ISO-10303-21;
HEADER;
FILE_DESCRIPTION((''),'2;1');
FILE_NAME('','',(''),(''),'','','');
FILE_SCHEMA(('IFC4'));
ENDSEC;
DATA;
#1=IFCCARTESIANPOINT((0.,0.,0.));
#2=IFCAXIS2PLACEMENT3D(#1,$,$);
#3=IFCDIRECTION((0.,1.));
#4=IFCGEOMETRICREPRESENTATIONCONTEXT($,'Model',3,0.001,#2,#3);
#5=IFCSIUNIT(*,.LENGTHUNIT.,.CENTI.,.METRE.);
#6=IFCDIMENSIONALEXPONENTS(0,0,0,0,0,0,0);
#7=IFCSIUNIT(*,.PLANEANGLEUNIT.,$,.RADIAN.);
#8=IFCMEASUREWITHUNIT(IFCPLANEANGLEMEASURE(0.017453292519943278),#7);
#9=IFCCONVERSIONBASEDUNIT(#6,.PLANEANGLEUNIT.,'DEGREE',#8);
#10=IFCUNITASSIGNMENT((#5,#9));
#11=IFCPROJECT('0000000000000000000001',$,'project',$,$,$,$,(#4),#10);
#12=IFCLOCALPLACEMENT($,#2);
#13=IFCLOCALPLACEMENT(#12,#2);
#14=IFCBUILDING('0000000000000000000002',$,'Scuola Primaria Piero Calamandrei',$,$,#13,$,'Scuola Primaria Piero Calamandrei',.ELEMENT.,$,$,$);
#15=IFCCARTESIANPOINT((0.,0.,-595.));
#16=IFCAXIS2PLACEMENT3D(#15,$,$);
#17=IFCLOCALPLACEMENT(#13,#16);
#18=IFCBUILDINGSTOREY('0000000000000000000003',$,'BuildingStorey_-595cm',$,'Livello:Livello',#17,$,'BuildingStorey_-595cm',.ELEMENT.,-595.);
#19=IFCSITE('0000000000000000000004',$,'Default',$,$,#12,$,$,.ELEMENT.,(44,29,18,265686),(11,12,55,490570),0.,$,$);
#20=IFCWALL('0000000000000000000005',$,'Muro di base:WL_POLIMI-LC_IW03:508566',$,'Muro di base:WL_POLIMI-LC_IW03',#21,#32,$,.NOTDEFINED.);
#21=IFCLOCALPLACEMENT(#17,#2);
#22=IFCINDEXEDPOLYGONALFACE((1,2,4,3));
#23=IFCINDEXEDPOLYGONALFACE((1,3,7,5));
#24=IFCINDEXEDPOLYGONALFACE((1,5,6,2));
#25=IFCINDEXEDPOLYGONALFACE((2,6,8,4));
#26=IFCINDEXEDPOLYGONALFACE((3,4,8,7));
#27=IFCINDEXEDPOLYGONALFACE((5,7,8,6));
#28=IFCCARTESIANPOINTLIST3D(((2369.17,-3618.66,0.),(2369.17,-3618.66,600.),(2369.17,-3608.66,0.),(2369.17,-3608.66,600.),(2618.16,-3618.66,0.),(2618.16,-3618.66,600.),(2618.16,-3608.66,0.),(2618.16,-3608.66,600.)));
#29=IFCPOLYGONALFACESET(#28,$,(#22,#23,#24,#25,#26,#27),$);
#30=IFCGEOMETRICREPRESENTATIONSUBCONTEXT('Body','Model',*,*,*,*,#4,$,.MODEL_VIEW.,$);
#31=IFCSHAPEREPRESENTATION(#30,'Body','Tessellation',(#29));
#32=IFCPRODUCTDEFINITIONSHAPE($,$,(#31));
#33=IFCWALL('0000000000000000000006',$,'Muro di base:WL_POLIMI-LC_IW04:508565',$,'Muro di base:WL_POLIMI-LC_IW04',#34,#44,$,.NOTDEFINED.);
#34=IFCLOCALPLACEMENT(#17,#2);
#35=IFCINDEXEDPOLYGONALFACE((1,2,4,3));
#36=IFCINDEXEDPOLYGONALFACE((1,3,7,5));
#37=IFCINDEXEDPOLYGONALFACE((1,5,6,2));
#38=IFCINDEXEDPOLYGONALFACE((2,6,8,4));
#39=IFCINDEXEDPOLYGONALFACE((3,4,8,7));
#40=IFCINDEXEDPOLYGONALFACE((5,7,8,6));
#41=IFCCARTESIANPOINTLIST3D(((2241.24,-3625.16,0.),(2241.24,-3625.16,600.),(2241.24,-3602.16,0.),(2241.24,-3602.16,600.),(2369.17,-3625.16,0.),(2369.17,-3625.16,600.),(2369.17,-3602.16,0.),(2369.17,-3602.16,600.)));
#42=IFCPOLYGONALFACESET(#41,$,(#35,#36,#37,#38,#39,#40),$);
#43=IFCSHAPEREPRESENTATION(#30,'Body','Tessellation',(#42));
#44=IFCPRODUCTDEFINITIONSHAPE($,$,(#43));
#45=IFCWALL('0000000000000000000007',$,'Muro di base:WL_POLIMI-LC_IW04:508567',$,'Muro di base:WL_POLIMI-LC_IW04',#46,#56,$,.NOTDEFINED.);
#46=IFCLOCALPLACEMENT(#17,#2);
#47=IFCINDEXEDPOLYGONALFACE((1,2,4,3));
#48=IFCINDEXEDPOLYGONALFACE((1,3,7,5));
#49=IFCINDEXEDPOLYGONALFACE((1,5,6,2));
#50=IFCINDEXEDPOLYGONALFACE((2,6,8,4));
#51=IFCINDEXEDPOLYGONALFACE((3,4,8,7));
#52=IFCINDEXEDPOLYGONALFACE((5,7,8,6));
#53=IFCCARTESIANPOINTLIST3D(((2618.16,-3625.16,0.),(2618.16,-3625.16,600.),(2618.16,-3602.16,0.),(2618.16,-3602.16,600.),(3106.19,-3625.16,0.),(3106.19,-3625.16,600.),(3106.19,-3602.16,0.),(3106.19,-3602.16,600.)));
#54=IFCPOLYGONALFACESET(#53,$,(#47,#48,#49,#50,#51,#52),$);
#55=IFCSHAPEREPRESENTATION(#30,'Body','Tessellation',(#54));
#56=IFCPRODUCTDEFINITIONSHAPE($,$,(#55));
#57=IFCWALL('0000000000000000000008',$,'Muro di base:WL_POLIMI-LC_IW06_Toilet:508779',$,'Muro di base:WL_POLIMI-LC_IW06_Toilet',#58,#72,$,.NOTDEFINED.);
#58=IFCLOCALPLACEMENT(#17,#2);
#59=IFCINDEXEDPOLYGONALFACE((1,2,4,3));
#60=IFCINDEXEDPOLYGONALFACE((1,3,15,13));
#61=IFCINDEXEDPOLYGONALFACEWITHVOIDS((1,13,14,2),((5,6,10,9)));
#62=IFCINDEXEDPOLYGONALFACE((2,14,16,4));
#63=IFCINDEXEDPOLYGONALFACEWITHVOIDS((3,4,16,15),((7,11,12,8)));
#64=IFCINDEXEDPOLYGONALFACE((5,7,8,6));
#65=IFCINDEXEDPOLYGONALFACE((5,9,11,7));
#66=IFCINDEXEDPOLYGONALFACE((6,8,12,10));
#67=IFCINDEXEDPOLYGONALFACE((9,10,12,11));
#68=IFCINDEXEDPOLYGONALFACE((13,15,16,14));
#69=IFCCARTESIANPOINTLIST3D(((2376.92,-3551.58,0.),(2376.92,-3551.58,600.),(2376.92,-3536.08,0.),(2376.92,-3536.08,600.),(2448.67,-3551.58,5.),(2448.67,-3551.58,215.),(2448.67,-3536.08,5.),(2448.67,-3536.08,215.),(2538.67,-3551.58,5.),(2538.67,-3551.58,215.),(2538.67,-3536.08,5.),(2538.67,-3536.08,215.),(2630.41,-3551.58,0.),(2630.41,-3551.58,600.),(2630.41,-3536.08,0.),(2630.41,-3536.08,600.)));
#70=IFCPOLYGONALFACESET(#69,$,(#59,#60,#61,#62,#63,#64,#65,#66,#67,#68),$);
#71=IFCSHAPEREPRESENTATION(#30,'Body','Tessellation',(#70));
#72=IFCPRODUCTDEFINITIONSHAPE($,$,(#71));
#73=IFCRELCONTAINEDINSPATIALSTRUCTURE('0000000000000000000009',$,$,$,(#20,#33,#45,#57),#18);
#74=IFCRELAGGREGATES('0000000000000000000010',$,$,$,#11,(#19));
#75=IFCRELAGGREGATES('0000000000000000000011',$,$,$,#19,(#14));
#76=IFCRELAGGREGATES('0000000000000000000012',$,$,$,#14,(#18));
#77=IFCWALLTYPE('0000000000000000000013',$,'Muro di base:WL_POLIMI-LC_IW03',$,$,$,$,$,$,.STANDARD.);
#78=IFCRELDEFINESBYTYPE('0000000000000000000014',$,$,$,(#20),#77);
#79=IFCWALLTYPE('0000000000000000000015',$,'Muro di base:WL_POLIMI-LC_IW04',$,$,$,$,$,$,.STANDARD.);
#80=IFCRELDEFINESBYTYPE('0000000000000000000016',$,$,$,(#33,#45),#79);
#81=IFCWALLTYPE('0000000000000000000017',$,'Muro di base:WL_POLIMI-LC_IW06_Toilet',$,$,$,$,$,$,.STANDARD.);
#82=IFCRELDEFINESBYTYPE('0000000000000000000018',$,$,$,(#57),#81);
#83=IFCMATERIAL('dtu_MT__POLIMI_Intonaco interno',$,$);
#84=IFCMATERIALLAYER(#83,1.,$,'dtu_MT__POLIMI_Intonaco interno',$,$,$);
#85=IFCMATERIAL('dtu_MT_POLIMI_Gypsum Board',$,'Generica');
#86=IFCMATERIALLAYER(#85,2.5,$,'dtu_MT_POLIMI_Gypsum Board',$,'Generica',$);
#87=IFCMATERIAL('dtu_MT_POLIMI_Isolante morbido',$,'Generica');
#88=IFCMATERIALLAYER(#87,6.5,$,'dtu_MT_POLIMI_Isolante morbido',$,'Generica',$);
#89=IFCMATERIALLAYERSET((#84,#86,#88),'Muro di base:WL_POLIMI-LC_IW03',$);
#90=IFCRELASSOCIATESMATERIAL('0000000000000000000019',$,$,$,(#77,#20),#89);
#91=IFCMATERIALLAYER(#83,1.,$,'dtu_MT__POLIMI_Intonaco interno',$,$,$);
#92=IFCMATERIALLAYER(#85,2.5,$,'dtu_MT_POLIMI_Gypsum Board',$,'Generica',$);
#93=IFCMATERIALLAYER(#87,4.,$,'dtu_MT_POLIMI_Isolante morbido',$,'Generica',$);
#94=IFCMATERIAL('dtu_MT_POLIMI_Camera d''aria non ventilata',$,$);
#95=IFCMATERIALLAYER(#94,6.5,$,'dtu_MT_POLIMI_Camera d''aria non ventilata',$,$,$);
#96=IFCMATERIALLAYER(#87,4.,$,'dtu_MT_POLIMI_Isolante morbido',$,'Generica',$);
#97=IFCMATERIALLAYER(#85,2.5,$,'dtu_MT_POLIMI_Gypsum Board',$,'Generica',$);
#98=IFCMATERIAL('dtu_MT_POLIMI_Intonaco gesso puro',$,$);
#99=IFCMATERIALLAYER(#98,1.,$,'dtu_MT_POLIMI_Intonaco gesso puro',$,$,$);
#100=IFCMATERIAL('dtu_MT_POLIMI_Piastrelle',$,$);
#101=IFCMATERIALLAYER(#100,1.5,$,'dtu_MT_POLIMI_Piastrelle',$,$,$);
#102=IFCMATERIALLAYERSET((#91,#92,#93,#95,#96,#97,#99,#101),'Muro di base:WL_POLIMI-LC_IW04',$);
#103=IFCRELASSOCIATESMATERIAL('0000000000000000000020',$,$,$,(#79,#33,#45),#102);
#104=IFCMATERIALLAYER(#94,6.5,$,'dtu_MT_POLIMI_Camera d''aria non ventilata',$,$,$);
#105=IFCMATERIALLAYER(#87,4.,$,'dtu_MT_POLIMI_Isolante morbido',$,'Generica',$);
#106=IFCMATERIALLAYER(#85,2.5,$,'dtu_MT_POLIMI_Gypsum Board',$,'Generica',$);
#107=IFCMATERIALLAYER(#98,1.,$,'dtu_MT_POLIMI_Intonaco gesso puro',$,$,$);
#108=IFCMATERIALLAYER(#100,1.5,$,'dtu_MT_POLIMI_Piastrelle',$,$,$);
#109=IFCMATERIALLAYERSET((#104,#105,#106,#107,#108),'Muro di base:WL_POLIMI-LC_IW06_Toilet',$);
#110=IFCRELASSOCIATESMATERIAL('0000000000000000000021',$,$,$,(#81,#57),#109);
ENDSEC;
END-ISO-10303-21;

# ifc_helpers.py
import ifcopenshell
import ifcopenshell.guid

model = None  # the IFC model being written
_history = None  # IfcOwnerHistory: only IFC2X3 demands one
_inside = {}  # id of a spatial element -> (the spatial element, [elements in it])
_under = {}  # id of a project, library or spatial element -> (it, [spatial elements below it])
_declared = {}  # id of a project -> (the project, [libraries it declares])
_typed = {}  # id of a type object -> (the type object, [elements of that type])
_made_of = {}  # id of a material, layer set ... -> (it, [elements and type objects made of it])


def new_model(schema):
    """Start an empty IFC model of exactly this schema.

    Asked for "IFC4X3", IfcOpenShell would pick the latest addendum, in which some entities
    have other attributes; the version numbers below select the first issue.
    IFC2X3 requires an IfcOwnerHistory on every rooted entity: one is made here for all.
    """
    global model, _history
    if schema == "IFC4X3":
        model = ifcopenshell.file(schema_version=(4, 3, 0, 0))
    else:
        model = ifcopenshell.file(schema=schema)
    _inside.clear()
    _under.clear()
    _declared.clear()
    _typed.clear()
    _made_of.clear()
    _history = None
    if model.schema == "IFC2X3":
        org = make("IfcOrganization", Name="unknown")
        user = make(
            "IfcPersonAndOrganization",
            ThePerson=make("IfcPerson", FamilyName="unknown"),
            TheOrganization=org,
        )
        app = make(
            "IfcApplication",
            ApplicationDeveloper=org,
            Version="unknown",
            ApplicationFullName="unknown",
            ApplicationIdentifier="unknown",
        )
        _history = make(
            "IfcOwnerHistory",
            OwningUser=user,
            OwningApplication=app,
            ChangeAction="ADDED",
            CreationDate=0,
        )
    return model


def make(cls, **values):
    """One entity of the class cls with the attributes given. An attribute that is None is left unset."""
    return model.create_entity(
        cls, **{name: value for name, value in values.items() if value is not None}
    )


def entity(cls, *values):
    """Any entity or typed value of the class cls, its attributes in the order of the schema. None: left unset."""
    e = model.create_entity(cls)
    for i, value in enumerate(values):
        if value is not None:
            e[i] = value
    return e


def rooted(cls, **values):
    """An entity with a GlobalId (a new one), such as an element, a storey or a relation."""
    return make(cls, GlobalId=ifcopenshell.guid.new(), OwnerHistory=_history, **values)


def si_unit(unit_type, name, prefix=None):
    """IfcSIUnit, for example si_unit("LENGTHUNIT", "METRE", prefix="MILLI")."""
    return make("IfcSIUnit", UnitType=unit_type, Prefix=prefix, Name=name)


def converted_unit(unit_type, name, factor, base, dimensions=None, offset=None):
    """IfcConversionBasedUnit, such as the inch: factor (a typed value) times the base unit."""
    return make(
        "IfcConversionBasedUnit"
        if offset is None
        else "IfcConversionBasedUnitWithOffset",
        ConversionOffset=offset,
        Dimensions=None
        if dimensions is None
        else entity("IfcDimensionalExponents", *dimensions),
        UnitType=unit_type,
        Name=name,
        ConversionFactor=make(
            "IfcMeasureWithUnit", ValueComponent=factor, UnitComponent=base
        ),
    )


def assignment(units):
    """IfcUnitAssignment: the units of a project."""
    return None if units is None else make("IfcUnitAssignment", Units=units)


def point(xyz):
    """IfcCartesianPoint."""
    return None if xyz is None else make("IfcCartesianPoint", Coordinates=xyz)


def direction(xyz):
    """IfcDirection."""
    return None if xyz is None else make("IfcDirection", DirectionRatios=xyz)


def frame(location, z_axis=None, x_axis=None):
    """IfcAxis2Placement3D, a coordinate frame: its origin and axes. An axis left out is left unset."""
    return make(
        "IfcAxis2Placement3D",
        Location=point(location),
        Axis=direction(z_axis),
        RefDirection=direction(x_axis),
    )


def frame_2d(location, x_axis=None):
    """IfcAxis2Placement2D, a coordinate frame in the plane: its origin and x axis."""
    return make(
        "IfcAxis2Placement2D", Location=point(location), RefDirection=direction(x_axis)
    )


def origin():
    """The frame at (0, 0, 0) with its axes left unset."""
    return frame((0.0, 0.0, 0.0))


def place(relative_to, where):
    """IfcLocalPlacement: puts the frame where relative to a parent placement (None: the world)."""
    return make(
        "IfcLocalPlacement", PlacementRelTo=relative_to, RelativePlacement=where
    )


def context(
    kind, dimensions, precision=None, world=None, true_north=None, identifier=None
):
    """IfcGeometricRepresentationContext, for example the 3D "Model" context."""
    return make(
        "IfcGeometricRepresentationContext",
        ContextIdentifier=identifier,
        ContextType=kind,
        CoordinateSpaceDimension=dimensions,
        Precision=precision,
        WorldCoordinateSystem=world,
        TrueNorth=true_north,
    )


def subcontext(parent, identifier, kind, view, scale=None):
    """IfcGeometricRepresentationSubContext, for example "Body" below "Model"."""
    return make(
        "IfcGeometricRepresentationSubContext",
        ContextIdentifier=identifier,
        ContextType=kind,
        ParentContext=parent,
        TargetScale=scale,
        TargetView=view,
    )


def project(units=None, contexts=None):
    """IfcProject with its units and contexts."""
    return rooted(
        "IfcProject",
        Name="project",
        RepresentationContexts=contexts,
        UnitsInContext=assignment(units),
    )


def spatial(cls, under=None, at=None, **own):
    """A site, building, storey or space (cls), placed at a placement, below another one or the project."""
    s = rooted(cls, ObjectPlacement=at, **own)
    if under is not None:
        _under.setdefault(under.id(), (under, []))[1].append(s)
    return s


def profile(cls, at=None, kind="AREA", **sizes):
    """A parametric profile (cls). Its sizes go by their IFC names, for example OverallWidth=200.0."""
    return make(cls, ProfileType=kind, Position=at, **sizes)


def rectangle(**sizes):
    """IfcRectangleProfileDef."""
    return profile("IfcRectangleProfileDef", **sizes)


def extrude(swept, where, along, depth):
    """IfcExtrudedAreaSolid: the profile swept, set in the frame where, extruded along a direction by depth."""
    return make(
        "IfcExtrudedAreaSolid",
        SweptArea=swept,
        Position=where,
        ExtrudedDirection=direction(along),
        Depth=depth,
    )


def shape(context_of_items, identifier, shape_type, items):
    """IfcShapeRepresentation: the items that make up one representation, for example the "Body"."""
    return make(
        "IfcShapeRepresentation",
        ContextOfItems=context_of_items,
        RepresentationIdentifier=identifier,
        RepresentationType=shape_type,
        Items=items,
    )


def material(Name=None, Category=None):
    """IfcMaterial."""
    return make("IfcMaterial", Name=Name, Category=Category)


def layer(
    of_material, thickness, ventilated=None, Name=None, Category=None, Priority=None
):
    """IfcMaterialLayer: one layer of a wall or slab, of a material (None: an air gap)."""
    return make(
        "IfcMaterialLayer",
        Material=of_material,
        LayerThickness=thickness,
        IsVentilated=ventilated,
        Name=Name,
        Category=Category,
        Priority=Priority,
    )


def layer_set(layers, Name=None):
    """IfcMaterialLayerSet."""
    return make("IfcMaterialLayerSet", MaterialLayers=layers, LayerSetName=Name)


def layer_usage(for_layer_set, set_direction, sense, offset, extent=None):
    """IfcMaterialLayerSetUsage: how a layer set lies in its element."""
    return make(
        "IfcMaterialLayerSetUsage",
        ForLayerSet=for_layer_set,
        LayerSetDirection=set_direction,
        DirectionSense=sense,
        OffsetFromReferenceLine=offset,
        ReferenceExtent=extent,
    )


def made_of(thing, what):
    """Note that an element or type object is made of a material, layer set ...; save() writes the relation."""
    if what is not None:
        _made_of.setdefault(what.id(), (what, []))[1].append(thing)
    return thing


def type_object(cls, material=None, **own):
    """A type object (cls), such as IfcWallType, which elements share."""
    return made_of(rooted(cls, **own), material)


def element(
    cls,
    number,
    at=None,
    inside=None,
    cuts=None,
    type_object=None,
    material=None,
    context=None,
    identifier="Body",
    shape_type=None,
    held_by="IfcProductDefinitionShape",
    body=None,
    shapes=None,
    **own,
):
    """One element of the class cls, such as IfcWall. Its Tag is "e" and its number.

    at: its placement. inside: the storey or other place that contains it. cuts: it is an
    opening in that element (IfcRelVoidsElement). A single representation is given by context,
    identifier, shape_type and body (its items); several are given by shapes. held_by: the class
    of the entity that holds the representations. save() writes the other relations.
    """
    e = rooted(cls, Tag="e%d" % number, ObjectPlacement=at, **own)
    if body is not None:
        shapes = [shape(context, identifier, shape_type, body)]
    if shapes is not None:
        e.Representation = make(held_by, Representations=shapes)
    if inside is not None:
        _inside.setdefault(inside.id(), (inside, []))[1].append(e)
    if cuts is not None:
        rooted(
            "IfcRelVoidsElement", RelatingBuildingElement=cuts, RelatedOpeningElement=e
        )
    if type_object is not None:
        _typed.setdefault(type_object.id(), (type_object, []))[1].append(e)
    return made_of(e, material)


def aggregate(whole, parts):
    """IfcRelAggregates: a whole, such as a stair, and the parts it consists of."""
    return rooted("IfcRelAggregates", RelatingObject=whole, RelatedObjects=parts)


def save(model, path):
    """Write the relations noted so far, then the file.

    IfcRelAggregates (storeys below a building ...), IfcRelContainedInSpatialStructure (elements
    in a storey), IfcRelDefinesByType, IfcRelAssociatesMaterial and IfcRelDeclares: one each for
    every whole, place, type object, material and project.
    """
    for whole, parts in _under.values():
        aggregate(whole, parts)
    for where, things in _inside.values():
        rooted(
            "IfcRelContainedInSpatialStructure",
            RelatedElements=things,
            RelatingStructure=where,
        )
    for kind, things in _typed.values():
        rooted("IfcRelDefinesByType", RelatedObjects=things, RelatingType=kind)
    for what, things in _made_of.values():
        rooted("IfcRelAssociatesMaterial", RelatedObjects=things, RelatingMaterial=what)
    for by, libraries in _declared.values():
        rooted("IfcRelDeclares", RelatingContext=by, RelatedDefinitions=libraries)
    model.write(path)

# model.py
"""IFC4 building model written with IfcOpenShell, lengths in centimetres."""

from ifc_helpers import new_model, entity, si_unit, converted_unit, direction, frame, frame_2d, origin, place, context, subcontext, project, spatial, rectangle, extrude, material, layer, layer_set, layer_usage, type_object, element, save


model = new_model("IFC4")

# Units and contexts
model_context = context("Model", 3, precision=0.001, world=origin(), true_north=direction((0.0, 1.0)))
body_context = subcontext(model_context, "Body", "Model", "MODEL_VIEW")
ifc_project = project(units=[si_unit("LENGTHUNIT", "METRE", prefix="CENTI"), converted_unit("PLANEANGLEUNIT", "DEGREE", entity("IfcPlaneAngleMeasure", 0.017453292519943278), si_unit("PLANEANGLEUNIT", "RADIAN"), dimensions=[0, 0, 0, 0, 0, 0, 0])], contexts=[model_context])

# Site, building, storey
site_placement = place(None, origin())
site = spatial("IfcSite", under=ifc_project, at=site_placement, Name="Default", CompositionType="ELEMENT", RefLatitude=(44, 29, 18, 265686), RefLongitude=(11, 12, 55, 490570), RefElevation=0.0)
building_placement = place(site_placement, origin())
building = spatial("IfcBuilding", under=site, at=building_placement, Name="Scuola Primaria Piero Calamandrei", LongName="Scuola Primaria Piero Calamandrei", CompositionType="ELEMENT")
storey_placement = place(building_placement, frame((0.0, 0.0, -595.0)))
storey = spatial("IfcBuildingStorey", under=building, at=storey_placement, Name="BuildingStorey_-595cm", ObjectType="Livello:Livello", LongName="BuildingStorey_-595cm", CompositionType="ELEMENT", Elevation=-595.0)

# Shared definitions
ifc_material_1 = material(Name="dtu_MT__POLIMI_Intonaco interno")
ifc_material_2 = material(Name="dtu_MT_POLIMI_Gypsum Board", Category="Generica")
ifc_material_3 = material(Name="dtu_MT_POLIMI_Isolante morbido", Category="Generica")
ifc_material_4 = material(Name="dtu_MT_POLIMI_Camera d'aria non ventilata")
ifc_material_5 = material(Name="dtu_MT_POLIMI_Intonaco gesso puro")

# Walls
ifc_layer_1 = layer(ifc_material_1, 1.0, Name="dtu_MT__POLIMI_Intonaco interno")
ifc_layer_2 = layer(ifc_material_2, 2.5, Name="dtu_MT_POLIMI_Gypsum Board", Category="Generica")
ifc_layer_3 = layer(ifc_material_3, 6.5, Name="dtu_MT_POLIMI_Isolante morbido", Category="Generica")
ifc_layer_set_1 = layer_set([ifc_layer_1, ifc_layer_2, ifc_layer_3], Name="Muro di base:WL_POLIMI-LC_IW03")
ifc_layer_usage_1 = layer_usage(ifc_layer_set_1, "AXIS2", "NEGATIVE", 5.0)
wall_type_1 = type_object("IfcWallType", Name="Muro di base:WL_POLIMI-LC_IW03", PredefinedType="STANDARD", material=ifc_layer_set_1)
wall_1_placement = place(storey_placement, frame((2369.17, -3613.66, 0.0)))
element("IfcWall", 1, at=wall_1_placement, inside=storey, type_object=wall_type_1, material=ifc_layer_usage_1, Name="Muro di base:WL_POLIMI-LC_IW03:508566", ObjectType="Muro di base:WL_POLIMI-LC_IW03", PredefinedType="NOTDEFINED", context=body_context, shape_type="SweptSolid", body=[
    extrude(rectangle(XDim=248.99, YDim=10.0, at=frame_2d((124.5, 0.0), x_axis=(-1.0, 0.0))), origin(), (0.0, 0.0, 1.0), 600.0),
])
ifc_layer_4 = layer(ifc_material_1, 1.0, Name="dtu_MT__POLIMI_Intonaco interno")
ifc_layer_5 = layer(ifc_material_2, 2.5, Name="dtu_MT_POLIMI_Gypsum Board", Category="Generica")
ifc_layer_6 = layer(ifc_material_3, 4.0, Name="dtu_MT_POLIMI_Isolante morbido", Category="Generica")
ifc_layer_7 = layer(ifc_material_4, 6.5, Name="dtu_MT_POLIMI_Camera d'aria non ventilata")
ifc_layer_8 = layer(ifc_material_3, 4.0, Name="dtu_MT_POLIMI_Isolante morbido", Category="Generica")
ifc_layer_9 = layer(ifc_material_2, 2.5, Name="dtu_MT_POLIMI_Gypsum Board", Category="Generica")
ifc_layer_10 = layer(ifc_material_5, 1.0, Name="dtu_MT_POLIMI_Intonaco gesso puro")
ifc_material_6 = material(Name="dtu_MT_POLIMI_Piastrelle")
ifc_layer_11 = layer(ifc_material_6, 1.5, Name="dtu_MT_POLIMI_Piastrelle")
ifc_layer_set_2 = layer_set([ifc_layer_4, ifc_layer_5, ifc_layer_6, ifc_layer_7, ifc_layer_8, ifc_layer_9, ifc_layer_10, ifc_layer_11], Name="Muro di base:WL_POLIMI-LC_IW04")
ifc_layer_usage_2 = layer_usage(ifc_layer_set_2, "AXIS2", "NEGATIVE", 11.5)
wall_type_2 = type_object("IfcWallType", Name="Muro di base:WL_POLIMI-LC_IW04", PredefinedType="STANDARD", material=ifc_layer_set_2)
wall_2_placement = place(storey_placement, frame((2241.24, -3613.66, 0.0)))
element("IfcWall", 2, at=wall_2_placement, inside=storey, type_object=wall_type_2, material=ifc_layer_usage_2, Name="Muro di base:WL_POLIMI-LC_IW04:508565", ObjectType="Muro di base:WL_POLIMI-LC_IW04", PredefinedType="NOTDEFINED", context=body_context, shape_type="SweptSolid", body=[
    extrude(rectangle(XDim=127.93, YDim=23.0, at=frame_2d((63.97, 0.0), x_axis=(-1.0, 0.0))), origin(), (0.0, 0.0, 1.0), 600.0),
])
ifc_layer_usage_3 = layer_usage(ifc_layer_set_2, "AXIS2", "NEGATIVE", 11.5)
wall_3_placement = place(storey_placement, frame((2618.16, -3613.66, 0.0)))
element("IfcWall", 3, at=wall_3_placement, inside=storey, type_object=wall_type_2, material=ifc_layer_usage_3, Name="Muro di base:WL_POLIMI-LC_IW04:508567", ObjectType="Muro di base:WL_POLIMI-LC_IW04", PredefinedType="NOTDEFINED", context=body_context, shape_type="SweptSolid", body=[
    extrude(rectangle(XDim=488.02, YDim=23.0, at=frame_2d((244.01, 0.0), x_axis=(-1.0, 0.0))), origin(), (0.0, 0.0, 1.0), 600.0),
])
ifc_layer_12 = layer(ifc_material_4, 6.5, Name="dtu_MT_POLIMI_Camera d'aria non ventilata")
ifc_layer_13 = layer(ifc_material_3, 4.0, Name="dtu_MT_POLIMI_Isolante morbido", Category="Generica")
ifc_layer_14 = layer(ifc_material_2, 2.5, Name="dtu_MT_POLIMI_Gypsum Board", Category="Generica")
ifc_layer_15 = layer(ifc_material_5, 1.0, Name="dtu_MT_POLIMI_Intonaco gesso puro")
ifc_layer_16 = layer(ifc_material_6, 1.5, Name="dtu_MT_POLIMI_Piastrelle")
ifc_layer_set_3 = layer_set([ifc_layer_12, ifc_layer_13, ifc_layer_14, ifc_layer_15, ifc_layer_16], Name="Muro di base:WL_POLIMI-LC_IW06_Toilet")
wall_type_3 = type_object("IfcWallType", Name="Muro di base:WL_POLIMI-LC_IW06_Toilet", PredefinedType="STANDARD", material=ifc_layer_set_3)

# Wall, opening
ifc_layer_usage_4 = layer_usage(ifc_layer_set_3, "AXIS2", "NEGATIVE", 7.75)
wall_4_placement = place(storey_placement, frame((2630.41, -3543.83, 0.0), z_axis=(0.0, 0.0, 1.0), x_axis=(-1.0, 0.0, 0.0)))
wall_4 = element("IfcWall", 4, at=wall_4_placement, inside=storey, type_object=wall_type_3, material=ifc_layer_usage_4, Name="Muro di base:WL_POLIMI-LC_IW06_Toilet:508779", ObjectType="Muro di base:WL_POLIMI-LC_IW06_Toilet", PredefinedType="NOTDEFINED", context=body_context, shape_type="SweptSolid", body=[
    extrude(rectangle(XDim=253.49, YDim=15.5, at=frame_2d((126.75, 0.0), x_axis=(-1.0, 0.0))), origin(), (0.0, 0.0, 1.0), 600.0),
])
opening_1_placement = place(wall_4_placement, frame((181.75, 7.75, 5.0)))
element("IfcOpeningElement", 5, at=opening_1_placement, cuts=wall_4, PredefinedType="OPENING", context=body_context, shape_type="SweptSolid", body=[
    extrude(rectangle(XDim=210.0, YDim=90.0, at=frame_2d((105.0, 45.0), x_axis=(1.0, 0.0))), frame((0.0, 0.0, 0.0), z_axis=(0.0, -1.0, 0.0), x_axis=(0.0, 0.0, 1.0)), (0.0, 0.0, 1.0), 15.5),
])

save(model, "model.ifc")
